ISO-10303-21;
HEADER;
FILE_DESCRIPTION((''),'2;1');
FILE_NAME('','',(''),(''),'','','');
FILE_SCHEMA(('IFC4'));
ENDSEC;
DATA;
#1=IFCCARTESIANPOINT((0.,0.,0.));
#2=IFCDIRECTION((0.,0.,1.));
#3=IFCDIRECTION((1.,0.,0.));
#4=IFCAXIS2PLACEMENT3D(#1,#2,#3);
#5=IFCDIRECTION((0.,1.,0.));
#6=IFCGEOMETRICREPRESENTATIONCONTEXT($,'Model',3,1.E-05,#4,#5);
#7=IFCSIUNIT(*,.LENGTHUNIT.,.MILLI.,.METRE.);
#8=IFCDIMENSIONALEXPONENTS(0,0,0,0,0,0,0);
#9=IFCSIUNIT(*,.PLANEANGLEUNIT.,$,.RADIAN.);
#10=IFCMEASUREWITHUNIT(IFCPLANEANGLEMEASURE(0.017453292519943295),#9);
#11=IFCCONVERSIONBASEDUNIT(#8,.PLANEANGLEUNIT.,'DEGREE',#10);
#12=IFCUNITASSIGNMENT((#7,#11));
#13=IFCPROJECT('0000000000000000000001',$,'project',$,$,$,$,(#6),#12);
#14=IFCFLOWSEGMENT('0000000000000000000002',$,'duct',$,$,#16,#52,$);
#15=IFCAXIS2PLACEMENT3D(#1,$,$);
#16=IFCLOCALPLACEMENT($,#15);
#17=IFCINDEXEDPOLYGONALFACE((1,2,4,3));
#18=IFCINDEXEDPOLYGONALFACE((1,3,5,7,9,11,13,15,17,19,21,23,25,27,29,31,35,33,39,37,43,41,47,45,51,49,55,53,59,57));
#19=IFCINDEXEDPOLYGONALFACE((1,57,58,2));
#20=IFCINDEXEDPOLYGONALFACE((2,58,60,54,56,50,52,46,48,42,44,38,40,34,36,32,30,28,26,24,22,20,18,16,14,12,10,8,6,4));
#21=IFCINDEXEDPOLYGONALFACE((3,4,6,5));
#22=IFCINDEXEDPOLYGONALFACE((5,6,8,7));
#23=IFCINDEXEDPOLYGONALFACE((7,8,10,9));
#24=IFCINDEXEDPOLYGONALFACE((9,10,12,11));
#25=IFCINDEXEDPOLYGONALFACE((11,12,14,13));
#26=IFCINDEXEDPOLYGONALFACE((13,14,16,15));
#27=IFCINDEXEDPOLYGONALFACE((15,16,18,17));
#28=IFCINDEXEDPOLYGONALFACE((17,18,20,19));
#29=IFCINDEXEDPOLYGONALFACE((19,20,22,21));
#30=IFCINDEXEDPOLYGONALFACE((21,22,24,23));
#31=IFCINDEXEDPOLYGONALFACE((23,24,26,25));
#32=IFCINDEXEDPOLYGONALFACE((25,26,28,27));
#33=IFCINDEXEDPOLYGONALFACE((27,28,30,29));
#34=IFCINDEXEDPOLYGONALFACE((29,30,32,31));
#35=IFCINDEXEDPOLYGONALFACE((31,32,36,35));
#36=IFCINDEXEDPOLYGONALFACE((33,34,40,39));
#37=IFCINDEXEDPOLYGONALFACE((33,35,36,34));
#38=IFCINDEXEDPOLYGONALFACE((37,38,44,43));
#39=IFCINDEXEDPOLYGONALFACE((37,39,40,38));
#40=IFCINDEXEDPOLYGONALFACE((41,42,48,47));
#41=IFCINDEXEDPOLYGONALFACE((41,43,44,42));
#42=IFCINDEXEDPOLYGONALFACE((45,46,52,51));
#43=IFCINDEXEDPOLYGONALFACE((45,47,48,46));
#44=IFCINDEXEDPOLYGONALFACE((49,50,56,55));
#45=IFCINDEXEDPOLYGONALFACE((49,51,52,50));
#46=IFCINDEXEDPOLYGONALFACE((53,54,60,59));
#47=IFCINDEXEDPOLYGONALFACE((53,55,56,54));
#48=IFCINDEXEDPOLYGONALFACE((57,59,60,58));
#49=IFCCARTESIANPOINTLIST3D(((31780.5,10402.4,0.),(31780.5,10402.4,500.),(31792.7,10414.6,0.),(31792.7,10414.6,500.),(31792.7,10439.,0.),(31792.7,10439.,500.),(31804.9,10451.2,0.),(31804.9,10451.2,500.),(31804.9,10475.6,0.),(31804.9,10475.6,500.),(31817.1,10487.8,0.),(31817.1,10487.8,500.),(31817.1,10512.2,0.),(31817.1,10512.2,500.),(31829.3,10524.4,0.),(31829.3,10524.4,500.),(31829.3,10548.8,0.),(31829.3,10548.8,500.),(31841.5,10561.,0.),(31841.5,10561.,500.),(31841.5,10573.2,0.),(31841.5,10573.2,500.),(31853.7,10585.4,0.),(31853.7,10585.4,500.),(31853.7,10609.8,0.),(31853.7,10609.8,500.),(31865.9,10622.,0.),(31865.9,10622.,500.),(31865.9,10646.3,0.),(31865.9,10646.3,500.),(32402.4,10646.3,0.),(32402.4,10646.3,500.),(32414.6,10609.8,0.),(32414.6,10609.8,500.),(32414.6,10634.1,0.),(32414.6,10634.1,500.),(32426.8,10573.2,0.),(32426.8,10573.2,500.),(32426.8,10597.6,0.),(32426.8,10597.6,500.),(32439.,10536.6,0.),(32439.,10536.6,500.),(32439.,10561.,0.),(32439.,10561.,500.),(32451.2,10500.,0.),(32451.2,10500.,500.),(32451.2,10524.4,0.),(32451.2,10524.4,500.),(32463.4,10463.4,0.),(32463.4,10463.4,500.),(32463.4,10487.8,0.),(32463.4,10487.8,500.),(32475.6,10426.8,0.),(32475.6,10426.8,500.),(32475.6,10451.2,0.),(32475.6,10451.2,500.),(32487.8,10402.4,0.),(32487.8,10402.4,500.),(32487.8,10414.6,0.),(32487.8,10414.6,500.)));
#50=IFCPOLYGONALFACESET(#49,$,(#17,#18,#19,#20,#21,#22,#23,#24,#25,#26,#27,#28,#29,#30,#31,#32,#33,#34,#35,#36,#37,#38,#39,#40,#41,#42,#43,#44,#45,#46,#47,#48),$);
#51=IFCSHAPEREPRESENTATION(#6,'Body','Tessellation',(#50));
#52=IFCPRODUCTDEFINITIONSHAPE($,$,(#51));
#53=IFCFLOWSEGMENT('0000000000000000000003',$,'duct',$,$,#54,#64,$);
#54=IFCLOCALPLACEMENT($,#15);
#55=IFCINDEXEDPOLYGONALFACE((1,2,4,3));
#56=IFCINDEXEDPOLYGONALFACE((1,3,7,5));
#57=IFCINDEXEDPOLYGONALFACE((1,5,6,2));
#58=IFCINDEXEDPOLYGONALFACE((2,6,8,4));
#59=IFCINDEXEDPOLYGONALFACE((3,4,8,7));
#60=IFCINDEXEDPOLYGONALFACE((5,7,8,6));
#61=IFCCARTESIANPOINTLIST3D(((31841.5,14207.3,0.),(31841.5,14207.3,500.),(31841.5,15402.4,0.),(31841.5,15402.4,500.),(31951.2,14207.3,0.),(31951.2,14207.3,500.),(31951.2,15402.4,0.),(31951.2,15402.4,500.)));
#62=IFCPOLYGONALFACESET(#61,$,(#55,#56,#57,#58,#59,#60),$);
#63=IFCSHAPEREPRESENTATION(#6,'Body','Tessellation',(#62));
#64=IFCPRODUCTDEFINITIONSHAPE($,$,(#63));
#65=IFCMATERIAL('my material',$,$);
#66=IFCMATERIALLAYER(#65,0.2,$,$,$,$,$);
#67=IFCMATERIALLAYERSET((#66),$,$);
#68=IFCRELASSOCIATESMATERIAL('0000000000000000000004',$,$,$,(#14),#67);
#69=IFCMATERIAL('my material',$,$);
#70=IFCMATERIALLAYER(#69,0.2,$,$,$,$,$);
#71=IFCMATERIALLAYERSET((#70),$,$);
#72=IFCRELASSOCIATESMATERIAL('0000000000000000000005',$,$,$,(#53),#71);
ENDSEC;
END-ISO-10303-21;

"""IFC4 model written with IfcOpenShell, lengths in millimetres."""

from ifc_helpers import new_model, entity, si_unit, converted_unit, direction, origin_with_axes, place, context, project, polyline, outline, extrude, material, layer, layer_set, layer_usage, element, save


model = new_model("IFC4")

# Units and contexts
model_context = context("Model", 3, precision=1e-05, world=origin_with_axes(), true_north=direction((0.0, 1.0, 0.0)))
ifc_project = project(units=[si_unit("LENGTHUNIT", "METRE", prefix="MILLI"), converted_unit("PLANEANGLEUNIT", "DEGREE", entity("IfcPlaneAngleMeasure", 0.017453292519943295), si_unit("PLANEANGLEUNIT", "RADIAN"), dimensions=[0, 0, 0, 0, 0, 0, 0])], contexts=[model_context])

# Flow segments
ifc_material_1 = material(Name="my material")
ifc_layer_1 = layer(ifc_material_1, 0.2)
ifc_layer_set_1 = layer_set([ifc_layer_1])
ifc_layer_usage_1 = layer_usage(ifc_layer_set_1, "AXIS2", "POSITIVE", -0.1)
flow_segment_1_placement = place(None, origin_with_axes())
element("IfcFlowSegment", 1, at=flow_segment_1_placement, material=ifc_layer_usage_1, Name="duct", context=model_context, shape_type="SweptSolid", body=[
    extrude(outline(polyline([(31780.5, 10402.4), (32487.8, 10402.4), (32487.8, 10414.6), (32475.6, 10426.8), (32475.6, 10451.2), (32463.4, 10463.4), (32463.4, 10487.8), (32451.2, 10500.0), (32451.2, 10524.4), (32439.0, 10536.6), (32439.0, 10561.0), (32426.8, 10573.2), (32426.8, 10597.6), (32414.6, 10609.8), (32414.6, 10634.1), (32402.4, 10646.3), (31865.9, 10646.3), (31865.9, 10622.0), (31853.7, 10609.8), (31853.7, 10585.4), (31841.5, 10573.2), (31841.5, 10561.0), (31829.3, 10548.8), (31829.3, 10524.4), (31817.1, 10512.2), (31817.1, 10487.8), (31804.9, 10475.6), (31804.9, 10451.2), (31792.7, 10439.0), (31792.7, 10414.6), (31780.5, 10402.4)])), origin_with_axes(), (0.0, 0.0, 1.0), 500.0),
])
ifc_material_2 = material(Name="my material")
ifc_layer_2 = layer(ifc_material_2, 0.2)
ifc_layer_set_2 = layer_set([ifc_layer_2])
ifc_layer_usage_2 = layer_usage(ifc_layer_set_2, "AXIS2", "POSITIVE", -0.1)
flow_segment_2_placement = place(None, origin_with_axes())
element("IfcFlowSegment", 2, at=flow_segment_2_placement, material=ifc_layer_usage_2, Name="duct", context=model_context, shape_type="SweptSolid", body=[
    extrude(outline(polyline([(31841.5, 14207.3), (31951.2, 14207.3), (31951.2, 15402.4), (31841.5, 15402.4), (31841.5, 14207.3)])), origin_with_axes(), (0.0, 0.0, 1.0), 500.0),
])

save(model, "model.ifc")
